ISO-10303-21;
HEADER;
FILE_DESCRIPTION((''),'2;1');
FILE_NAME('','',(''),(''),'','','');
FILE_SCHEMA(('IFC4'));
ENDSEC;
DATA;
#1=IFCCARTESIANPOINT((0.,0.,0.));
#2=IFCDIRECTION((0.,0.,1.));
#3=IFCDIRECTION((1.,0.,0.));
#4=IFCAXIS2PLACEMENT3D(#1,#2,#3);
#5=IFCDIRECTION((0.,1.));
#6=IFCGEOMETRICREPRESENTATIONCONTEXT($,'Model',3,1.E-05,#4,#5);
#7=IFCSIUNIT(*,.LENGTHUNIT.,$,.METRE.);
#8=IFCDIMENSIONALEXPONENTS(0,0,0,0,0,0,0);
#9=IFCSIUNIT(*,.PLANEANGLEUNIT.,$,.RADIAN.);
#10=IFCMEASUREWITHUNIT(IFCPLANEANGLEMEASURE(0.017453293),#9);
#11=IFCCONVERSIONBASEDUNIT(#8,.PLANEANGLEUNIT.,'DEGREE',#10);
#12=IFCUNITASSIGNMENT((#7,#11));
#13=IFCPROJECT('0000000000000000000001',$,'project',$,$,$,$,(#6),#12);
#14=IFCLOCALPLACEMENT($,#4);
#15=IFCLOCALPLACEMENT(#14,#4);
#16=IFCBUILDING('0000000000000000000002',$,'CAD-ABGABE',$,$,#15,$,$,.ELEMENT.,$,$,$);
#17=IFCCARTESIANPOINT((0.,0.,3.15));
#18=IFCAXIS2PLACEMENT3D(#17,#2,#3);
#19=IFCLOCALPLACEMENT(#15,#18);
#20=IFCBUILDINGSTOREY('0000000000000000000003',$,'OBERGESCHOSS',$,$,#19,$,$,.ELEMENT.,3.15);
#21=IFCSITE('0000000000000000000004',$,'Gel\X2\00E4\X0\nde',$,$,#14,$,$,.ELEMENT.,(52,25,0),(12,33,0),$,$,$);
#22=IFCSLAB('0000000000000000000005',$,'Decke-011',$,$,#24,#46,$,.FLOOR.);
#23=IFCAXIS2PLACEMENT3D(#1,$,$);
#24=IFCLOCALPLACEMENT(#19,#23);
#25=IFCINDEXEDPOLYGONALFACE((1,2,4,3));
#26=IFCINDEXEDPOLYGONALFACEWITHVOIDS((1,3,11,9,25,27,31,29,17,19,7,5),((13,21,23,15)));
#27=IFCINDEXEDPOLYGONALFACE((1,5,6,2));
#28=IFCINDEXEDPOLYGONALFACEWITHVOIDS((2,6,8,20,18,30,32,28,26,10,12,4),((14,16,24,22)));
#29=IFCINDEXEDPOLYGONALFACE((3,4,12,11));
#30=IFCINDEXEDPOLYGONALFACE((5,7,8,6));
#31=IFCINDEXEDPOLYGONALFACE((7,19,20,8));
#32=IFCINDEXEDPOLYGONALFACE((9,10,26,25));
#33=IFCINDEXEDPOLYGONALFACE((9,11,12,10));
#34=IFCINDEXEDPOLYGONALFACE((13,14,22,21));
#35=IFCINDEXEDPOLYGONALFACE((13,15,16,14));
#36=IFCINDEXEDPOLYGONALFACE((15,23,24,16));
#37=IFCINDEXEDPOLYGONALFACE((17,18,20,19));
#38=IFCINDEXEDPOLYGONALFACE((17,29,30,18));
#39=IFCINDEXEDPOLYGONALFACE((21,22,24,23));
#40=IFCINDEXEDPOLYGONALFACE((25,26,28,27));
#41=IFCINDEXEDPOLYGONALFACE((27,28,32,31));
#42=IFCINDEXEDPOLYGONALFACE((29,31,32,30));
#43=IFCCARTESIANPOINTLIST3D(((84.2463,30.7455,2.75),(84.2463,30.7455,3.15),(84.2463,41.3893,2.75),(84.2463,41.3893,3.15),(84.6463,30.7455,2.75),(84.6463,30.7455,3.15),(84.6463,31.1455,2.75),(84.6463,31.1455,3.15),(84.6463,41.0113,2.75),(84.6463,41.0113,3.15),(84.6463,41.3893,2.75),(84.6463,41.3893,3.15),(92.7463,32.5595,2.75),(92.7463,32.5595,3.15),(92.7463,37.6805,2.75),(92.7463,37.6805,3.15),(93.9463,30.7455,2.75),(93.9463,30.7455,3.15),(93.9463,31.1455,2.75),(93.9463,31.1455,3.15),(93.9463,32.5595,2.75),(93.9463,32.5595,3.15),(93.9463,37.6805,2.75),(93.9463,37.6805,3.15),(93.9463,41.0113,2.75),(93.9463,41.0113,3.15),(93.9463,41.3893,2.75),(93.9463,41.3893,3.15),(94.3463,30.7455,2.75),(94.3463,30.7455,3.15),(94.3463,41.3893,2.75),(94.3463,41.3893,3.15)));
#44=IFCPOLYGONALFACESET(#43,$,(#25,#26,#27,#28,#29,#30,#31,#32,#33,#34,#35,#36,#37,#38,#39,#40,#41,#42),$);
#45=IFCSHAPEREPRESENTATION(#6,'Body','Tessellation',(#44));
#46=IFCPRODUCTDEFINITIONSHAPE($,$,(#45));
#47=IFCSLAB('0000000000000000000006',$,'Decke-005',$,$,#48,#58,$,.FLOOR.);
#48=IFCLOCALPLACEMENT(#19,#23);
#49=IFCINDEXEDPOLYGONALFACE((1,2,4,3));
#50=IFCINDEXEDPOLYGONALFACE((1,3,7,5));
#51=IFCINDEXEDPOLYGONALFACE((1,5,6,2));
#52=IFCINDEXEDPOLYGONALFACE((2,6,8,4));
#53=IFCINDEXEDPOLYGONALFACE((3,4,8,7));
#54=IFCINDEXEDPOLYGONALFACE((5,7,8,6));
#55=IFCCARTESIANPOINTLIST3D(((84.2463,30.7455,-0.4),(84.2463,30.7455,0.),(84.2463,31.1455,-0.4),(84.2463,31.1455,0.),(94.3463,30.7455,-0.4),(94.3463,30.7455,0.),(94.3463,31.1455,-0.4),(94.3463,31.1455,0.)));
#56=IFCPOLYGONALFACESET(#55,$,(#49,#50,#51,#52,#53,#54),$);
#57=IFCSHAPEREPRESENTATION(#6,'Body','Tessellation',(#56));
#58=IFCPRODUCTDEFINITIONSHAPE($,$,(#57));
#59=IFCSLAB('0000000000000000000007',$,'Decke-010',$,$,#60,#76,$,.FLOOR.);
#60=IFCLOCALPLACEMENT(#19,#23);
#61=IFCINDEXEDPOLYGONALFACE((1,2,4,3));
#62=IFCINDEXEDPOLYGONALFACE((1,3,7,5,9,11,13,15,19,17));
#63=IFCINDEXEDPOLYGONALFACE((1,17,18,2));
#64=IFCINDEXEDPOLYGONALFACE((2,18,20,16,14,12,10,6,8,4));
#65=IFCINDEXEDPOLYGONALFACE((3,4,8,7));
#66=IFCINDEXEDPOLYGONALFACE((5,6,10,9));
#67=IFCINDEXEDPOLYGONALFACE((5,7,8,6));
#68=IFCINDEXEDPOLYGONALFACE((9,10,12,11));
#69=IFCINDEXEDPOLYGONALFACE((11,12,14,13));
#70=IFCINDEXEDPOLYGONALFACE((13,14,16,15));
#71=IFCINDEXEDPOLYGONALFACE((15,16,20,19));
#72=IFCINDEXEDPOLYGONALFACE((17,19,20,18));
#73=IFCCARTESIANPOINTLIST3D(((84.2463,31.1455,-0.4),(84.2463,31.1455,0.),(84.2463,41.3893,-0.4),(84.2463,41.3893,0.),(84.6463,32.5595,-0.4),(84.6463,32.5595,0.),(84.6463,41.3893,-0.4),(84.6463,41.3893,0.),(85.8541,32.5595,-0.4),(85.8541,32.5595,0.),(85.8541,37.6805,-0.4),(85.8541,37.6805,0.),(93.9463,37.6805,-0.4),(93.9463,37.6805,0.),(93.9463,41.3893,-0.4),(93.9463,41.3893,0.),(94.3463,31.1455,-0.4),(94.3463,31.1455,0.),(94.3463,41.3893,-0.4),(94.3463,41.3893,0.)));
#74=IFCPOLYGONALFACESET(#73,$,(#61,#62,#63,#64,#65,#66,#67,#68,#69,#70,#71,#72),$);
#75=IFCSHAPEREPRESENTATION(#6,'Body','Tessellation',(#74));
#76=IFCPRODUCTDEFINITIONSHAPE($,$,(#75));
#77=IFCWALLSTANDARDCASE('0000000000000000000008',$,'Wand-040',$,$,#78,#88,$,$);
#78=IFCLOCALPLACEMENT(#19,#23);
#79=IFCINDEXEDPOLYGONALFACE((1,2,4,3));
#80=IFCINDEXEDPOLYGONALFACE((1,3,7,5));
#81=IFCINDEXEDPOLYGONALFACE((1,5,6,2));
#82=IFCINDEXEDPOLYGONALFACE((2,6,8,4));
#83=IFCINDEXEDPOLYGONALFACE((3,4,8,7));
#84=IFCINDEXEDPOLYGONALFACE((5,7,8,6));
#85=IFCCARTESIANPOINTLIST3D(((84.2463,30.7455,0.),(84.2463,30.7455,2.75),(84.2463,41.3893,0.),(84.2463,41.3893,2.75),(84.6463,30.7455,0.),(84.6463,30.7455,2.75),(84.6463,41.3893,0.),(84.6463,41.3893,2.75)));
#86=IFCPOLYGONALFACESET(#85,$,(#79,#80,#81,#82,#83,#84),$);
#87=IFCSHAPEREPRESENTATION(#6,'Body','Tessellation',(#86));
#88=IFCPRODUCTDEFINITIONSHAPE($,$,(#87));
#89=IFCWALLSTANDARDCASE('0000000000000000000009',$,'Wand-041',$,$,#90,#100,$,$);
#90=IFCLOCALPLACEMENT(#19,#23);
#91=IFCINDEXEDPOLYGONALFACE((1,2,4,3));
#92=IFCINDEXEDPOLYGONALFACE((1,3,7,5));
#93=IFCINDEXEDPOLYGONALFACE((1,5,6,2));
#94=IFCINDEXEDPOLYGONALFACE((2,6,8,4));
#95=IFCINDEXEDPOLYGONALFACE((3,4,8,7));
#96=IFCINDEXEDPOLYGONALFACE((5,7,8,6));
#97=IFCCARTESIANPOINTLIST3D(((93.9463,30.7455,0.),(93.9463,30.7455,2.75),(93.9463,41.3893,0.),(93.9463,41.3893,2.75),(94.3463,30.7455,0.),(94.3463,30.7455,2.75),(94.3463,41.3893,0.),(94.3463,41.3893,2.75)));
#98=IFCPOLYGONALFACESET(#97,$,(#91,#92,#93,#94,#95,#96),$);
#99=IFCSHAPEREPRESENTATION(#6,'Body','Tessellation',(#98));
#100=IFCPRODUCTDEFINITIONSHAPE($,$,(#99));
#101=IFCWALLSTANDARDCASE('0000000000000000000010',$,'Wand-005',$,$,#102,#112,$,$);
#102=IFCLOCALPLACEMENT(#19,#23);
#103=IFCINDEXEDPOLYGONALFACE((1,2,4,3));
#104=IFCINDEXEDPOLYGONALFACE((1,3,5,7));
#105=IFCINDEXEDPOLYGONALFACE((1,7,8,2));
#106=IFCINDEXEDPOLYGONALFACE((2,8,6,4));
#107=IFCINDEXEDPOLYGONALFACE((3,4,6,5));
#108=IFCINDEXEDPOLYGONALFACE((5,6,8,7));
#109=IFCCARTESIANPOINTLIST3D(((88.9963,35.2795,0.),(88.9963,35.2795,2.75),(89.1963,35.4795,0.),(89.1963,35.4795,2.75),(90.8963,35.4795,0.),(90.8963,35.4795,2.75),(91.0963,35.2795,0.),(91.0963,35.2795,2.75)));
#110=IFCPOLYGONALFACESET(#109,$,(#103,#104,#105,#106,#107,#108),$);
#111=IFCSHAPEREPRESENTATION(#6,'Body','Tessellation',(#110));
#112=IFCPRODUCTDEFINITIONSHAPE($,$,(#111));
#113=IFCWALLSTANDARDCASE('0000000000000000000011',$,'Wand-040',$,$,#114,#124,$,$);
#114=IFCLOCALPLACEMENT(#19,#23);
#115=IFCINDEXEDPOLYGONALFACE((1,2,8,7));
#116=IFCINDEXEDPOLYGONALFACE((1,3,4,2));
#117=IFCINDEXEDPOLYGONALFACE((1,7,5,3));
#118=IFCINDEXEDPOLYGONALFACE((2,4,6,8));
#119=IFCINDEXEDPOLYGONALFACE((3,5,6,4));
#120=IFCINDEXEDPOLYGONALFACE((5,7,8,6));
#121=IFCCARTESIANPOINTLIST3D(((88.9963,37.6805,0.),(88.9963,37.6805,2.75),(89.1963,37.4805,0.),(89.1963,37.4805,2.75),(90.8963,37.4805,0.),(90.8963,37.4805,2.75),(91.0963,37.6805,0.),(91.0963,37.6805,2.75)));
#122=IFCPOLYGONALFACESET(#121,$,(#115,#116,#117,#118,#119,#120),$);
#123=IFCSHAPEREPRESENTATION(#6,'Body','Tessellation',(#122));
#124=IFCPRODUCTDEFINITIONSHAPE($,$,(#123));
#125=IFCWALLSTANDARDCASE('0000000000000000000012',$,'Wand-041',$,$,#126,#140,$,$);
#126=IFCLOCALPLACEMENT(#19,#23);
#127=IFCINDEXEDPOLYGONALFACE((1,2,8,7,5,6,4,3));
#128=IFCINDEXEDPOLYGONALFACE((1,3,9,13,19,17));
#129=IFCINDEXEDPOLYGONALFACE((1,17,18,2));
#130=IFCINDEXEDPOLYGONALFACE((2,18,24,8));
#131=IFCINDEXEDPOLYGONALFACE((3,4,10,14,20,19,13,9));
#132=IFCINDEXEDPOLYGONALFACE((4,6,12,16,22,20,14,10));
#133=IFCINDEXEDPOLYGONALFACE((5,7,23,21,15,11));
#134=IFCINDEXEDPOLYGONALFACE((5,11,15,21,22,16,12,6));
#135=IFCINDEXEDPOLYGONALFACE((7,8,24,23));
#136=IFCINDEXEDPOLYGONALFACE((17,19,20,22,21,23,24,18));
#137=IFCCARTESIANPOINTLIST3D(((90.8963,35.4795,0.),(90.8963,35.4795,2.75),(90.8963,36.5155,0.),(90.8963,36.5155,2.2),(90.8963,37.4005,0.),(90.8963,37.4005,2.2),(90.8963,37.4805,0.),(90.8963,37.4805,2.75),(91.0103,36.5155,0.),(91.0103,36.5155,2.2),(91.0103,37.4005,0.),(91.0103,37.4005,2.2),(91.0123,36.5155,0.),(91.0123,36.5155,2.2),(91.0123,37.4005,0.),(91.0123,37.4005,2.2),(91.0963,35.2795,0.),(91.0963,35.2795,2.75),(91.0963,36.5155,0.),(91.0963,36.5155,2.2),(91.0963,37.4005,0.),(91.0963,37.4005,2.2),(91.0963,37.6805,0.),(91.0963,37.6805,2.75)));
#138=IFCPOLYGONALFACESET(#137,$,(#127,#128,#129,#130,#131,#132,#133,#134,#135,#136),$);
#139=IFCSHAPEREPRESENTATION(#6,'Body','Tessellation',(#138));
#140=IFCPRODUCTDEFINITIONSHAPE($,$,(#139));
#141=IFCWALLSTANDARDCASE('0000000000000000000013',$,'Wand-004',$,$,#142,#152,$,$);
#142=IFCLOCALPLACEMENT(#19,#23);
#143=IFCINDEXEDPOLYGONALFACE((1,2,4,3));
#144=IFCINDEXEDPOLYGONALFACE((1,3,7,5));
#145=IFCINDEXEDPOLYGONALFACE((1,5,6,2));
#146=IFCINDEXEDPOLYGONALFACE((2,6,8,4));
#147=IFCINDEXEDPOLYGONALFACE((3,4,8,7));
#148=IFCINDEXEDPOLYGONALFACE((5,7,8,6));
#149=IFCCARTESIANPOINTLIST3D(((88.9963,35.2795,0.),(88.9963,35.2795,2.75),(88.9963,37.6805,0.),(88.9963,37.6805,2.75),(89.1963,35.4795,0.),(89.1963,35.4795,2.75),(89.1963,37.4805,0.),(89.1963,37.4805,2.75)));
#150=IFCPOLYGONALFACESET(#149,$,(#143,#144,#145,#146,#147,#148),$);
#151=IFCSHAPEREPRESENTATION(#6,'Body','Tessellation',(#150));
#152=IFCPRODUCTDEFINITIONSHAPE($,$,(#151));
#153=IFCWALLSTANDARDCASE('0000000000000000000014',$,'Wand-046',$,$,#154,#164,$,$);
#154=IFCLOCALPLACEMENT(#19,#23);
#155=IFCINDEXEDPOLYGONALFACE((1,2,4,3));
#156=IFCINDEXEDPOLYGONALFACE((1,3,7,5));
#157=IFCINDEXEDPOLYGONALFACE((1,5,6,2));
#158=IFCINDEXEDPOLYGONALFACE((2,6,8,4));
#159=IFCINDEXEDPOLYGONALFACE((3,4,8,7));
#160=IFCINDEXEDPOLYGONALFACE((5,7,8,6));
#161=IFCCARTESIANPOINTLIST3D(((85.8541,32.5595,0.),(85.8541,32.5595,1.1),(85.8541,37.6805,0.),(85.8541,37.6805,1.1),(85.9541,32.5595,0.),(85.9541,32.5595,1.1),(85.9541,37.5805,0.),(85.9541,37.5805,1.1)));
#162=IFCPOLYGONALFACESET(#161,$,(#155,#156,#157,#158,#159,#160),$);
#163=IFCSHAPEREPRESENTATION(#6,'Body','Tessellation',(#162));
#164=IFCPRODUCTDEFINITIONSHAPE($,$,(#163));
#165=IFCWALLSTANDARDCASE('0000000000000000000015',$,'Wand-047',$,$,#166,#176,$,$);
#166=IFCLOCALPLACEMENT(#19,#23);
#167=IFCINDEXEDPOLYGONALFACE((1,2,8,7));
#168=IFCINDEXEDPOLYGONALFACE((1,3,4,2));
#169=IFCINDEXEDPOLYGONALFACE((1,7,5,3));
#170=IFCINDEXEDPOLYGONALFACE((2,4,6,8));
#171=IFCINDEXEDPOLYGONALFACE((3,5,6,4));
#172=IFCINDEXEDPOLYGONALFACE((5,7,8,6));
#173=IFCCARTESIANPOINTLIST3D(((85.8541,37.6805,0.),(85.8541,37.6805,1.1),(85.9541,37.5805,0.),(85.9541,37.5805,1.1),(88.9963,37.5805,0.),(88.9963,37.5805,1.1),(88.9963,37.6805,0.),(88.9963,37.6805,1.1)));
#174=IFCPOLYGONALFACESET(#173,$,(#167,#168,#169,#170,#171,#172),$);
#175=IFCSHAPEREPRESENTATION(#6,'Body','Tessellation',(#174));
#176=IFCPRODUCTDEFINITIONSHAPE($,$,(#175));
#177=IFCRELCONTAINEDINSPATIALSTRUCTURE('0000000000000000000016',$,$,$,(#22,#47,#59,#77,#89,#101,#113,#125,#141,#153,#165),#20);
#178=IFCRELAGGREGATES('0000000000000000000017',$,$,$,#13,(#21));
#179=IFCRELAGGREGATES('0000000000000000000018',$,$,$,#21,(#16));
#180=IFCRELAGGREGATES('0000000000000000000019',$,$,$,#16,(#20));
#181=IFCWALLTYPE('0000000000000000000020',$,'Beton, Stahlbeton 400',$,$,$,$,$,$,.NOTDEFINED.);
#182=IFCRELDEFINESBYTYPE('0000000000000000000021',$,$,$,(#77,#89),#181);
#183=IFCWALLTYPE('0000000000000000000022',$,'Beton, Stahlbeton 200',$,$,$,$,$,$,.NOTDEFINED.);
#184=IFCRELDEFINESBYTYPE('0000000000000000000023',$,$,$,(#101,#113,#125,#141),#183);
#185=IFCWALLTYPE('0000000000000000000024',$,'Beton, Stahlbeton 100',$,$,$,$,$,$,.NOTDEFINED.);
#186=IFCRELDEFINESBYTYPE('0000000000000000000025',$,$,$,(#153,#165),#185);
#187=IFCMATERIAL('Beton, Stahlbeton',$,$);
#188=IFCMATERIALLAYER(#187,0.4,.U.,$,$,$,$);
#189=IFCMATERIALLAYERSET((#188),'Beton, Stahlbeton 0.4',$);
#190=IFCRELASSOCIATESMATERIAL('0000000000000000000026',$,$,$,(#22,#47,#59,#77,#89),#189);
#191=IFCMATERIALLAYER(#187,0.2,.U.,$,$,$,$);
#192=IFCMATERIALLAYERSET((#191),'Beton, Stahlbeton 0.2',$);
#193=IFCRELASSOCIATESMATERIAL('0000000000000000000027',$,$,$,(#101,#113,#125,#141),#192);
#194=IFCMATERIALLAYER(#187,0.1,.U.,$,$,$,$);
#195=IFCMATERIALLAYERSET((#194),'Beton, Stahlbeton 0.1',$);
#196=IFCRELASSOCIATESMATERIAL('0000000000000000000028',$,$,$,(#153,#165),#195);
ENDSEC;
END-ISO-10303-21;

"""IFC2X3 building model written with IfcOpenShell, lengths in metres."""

from ifc_helpers import new_model, entity, si_unit, converted_unit, direction, frame, origin_with_axes, origin_2d_with_axis, place, context, project, spatial, polyline, rectangle, outline, extrude, material, layer, layer_set, layer_usage, type_object, element, save


model = new_model("IFC2X3")

# Units and contexts
model_context = context("Model", 3, precision=1e-05, world=origin_with_axes(), true_north=direction((0.0, 1.0)))
ifc_project = project(units=[si_unit("LENGTHUNIT", "METRE"), converted_unit("PLANEANGLEUNIT", "DEGREE", entity("IfcPlaneAngleMeasure", 0.017453293), si_unit("PLANEANGLEUNIT", "RADIAN"), dimensions=[0, 0, 0, 0, 0, 0, 0])], contexts=[model_context])

# Site, building, storey
site_placement = place(None, origin_with_axes())
site = spatial("IfcSite", under=ifc_project, at=site_placement, Name="Gelände", CompositionType="ELEMENT", RefLatitude=(52, 25, 0), RefLongitude=(12, 33, 0))
building_placement = place(site_placement, origin_with_axes())
building = spatial("IfcBuilding", under=site, at=building_placement, Name="CAD-ABGABE", CompositionType="ELEMENT")
storey_placement = place(building_placement, frame((0.0, 0.0, 3.15), z_axis=(0.0, 0.0, 1.0), x_axis=(1.0, 0.0, 0.0)))
storey = spatial("IfcBuildingStorey", under=building, at=storey_placement, Name="OBERGESCHOSS", CompositionType="ELEMENT", Elevation=3.15)

# Slabs
ifc_material = material(Name="Beton, Stahlbeton")
ifc_layer_1 = layer(ifc_material, 0.4, ventilated="UNKNOWN")
ifc_layer_set_1 = layer_set([ifc_layer_1], Name="Beton, Stahlbeton 0.4")
ifc_layer_usage_1 = layer_usage(ifc_layer_set_1, "AXIS3", "NEGATIVE", 0.4)
slab_1_placement = place(storey_placement, frame((84.2463, 41.3893, 2.75), z_axis=(0.0, 0.0, 1.0), x_axis=(1.0, 0.0, 0.0)))
element("IfcSlab", 1, at=slab_1_placement, inside=storey, material=ifc_layer_usage_1, Name="Decke-011", PredefinedType="FLOOR", context=model_context, shape_type="SweptSolid", body=[
    extrude(outline(polyline([(0.0, 0.0), (0.0, -10.6437), (0.4, -10.6437), (0.4, -10.2437), (9.7, -10.2437), (9.7, -10.6437), (10.1, -10.6437), (10.1, 0.0), (9.7, 0.0), (9.7, -0.378), (0.4, -0.378), (0.4, 0.0), (0.0, 0.0)]), holes=[polyline([(8.5, -3.7087), (9.7, -3.7087), (9.7, -8.8298), (8.5, -8.8298), (8.5, -3.7087)])]), origin_with_axes(), (0.0, 0.0, 1.0), 0.4),
])
ifc_layer_usage_2 = layer_usage(ifc_layer_set_1, "AXIS3", "NEGATIVE", 0.4)
slab_2_placement = place(storey_placement, frame((84.2463, 31.1455, -0.4), z_axis=(0.0, 0.0, 1.0), x_axis=(1.0, 0.0, 0.0)))
element("IfcSlab", 2, at=slab_2_placement, inside=storey, material=ifc_layer_usage_2, Name="Decke-005", PredefinedType="FLOOR", context=model_context, shape_type="SweptSolid", body=[
    extrude(outline(polyline([(0.0, 0.0), (0.0, -0.4), (10.1, -0.4), (10.1, 0.0), (0.0, 0.0)])), origin_with_axes(), (0.0, 0.0, 1.0), 0.4),
])
ifc_layer_usage_3 = layer_usage(ifc_layer_set_1, "AXIS3", "NEGATIVE", 0.4)
slab_3_placement = place(storey_placement, frame((84.6463, 41.3893, -0.4), z_axis=(0.0, 0.0, 1.0), x_axis=(1.0, 0.0, 0.0)))
element("IfcSlab", 3, at=slab_3_placement, inside=storey, material=ifc_layer_usage_3, Name="Decke-010", PredefinedType="FLOOR", context=model_context, shape_type="SweptSolid", body=[
    extrude(outline(polyline([(0.0, 0.0), (-0.4, 0.0), (-0.4, -10.2437), (9.7, -10.2437), (9.7, 0.0), (9.3, 0.0), (9.3, -3.7087), (1.2077, -3.7087), (1.2077, -8.8298), (0.0, -8.8298), (0.0, 0.0)])), origin_with_axes(), (0.0, 0.0, 1.0), 0.4),
])

# Shared definitions
wall_type_1 = type_object("IfcWallType", Name="Beton, Stahlbeton 400", PredefinedType="NOTDEFINED")

# Walls
ifc_layer_usage_4 = layer_usage(ifc_layer_set_1, "AXIS2", "POSITIVE", 0.0)
wall_1_placement = place(storey_placement, frame((84.2463, 41.3893, 0.0), z_axis=(0.0, 0.0, 1.0), x_axis=(0.0, -1.0, 0.0)))
element("IfcWallStandardCase", 4, at=wall_1_placement, inside=storey, type_object=wall_type_1, material=ifc_layer_usage_4, Name="Wand-040", context=model_context, shape_type="SweptSolid", body=[
    extrude(outline(polyline([(0.0, 0.0), (10.6437, 0.0), (10.6437, 0.4), (0.0, 0.4), (0.0, 0.0)])), origin_with_axes(), (0.0, 0.0, 1.0), 2.75),
])
ifc_layer_usage_5 = layer_usage(ifc_layer_set_1, "AXIS2", "POSITIVE", 0.0)
wall_2_placement = place(storey_placement, frame((94.3463, 30.7455, 0.0), z_axis=(0.0, 0.0, 1.0), x_axis=(0.0, 1.0, 0.0)))
element("IfcWallStandardCase", 5, at=wall_2_placement, inside=storey, type_object=wall_type_1, material=ifc_layer_usage_5, Name="Wand-041", context=model_context, shape_type="SweptSolid", body=[
    extrude(outline(polyline([(0.0, 0.0), (10.6437, 0.0), (10.6437, 0.4), (0.0, 0.4), (0.0, 0.0)])), origin_with_axes(), (0.0, 0.0, 1.0), 2.75),
])
ifc_layer_2 = layer(ifc_material, 0.2, ventilated="UNKNOWN")
ifc_layer_set_2 = layer_set([ifc_layer_2], Name="Beton, Stahlbeton 0.2")
ifc_layer_usage_6 = layer_usage(ifc_layer_set_2, "AXIS2", "NEGATIVE", 0.0)
wall_type_2 = type_object("IfcWallType", Name="Beton, Stahlbeton 200", PredefinedType="NOTDEFINED")
wall_3_placement = place(storey_placement, frame((88.9963, 35.4795, 0.0), z_axis=(0.0, 0.0, 1.0), x_axis=(1.0, 0.0, 0.0)))
element("IfcWallStandardCase", 6, at=wall_3_placement, inside=storey, type_object=wall_type_2, material=ifc_layer_usage_6, Name="Wand-005", context=model_context, shape_type="SweptSolid", body=[
    extrude(outline(polyline([(0.0, -0.2), (2.1, -0.2), (1.9, 0.0), (0.2, 0.0), (0.0, -0.2)])), origin_with_axes(), (0.0, 0.0, 1.0), 2.75),
])
ifc_layer_usage_7 = layer_usage(ifc_layer_set_2, "AXIS2", "POSITIVE", 0.0)
wall_4_placement = place(storey_placement, frame((91.0963, 37.6805, 0.0), z_axis=(0.0, 0.0, 1.0), x_axis=(-1.0, 0.0, 0.0)))
element("IfcWallStandardCase", 7, at=wall_4_placement, inside=storey, type_object=wall_type_2, material=ifc_layer_usage_7, Name="Wand-040", context=model_context, shape_type="SweptSolid", body=[
    extrude(outline(polyline([(0.0, 0.0), (2.1, 0.0), (1.9, 0.2), (0.2, 0.2), (0.0, 0.0)])), origin_with_axes(), (0.0, 0.0, 1.0), 2.75),
])

# Wall, opening
ifc_layer_usage_8 = layer_usage(ifc_layer_set_2, "AXIS2", "NEGATIVE", 0.0)
wall_5_placement = place(storey_placement, frame((91.0963, 37.6805, 0.0), z_axis=(0.0, 0.0, 1.0), x_axis=(0.0, -1.0, 0.0)))
wall_5 = element("IfcWallStandardCase", 8, at=wall_5_placement, inside=storey, type_object=wall_type_2, material=ifc_layer_usage_8, Name="Wand-041", context=model_context, shape_type="SweptSolid", body=[
    extrude(outline(polyline([(0.2, -0.2), (2.201, -0.2), (2.401, 0.0), (0.0, 0.0), (0.2, -0.2)])), origin_with_axes(), (0.0, 0.0, 1.0), 2.75),
])
opening_1_placement = place(wall_5_placement, frame((0.7225, 0.0, 0.0), z_axis=(0.0, 0.0, 1.0), x_axis=(1.0, 0.0, 0.0)))
element("IfcOpeningElement", 9, at=opening_1_placement, cuts=wall_5, context=model_context, shape_type="SweptSolid", body=[
    extrude(rectangle(XDim=0.885, YDim=2.2, at=origin_2d_with_axis()), frame((0.0, -0.601, 1.1), z_axis=(0.0, 1.0, 0.0), x_axis=(1.0, 0.0, 0.0)), (0.0, 0.0, 1.0), 0.517),
    extrude(rectangle(XDim=0.885, YDim=2.2, at=origin_2d_with_axis()), frame((0.0, 0.401, 1.1), z_axis=(0.0, -1.0, 0.0), x_axis=(1.0, 0.0, 0.0)), (0.0, 0.0, 1.0), 0.487),
])

# Wall
ifc_layer_usage_9 = layer_usage(ifc_layer_set_2, "AXIS2", "POSITIVE", 0.0)
wall_6_placement = place(storey_placement, frame((88.9963, 37.6805, 0.0), z_axis=(0.0, 0.0, 1.0), x_axis=(0.0, -1.0, 0.0)))
element("IfcWallStandardCase", 10, at=wall_6_placement, inside=storey, type_object=wall_type_2, material=ifc_layer_usage_9, Name="Wand-004", context=model_context, shape_type="SweptSolid", body=[
    extrude(outline(polyline([(0.0, 0.0), (2.401, 0.0), (2.201, 0.2), (0.2, 0.2), (0.0, 0.0)])), origin_with_axes(), (0.0, 0.0, 1.0), 2.75),
])

# Shared definitions
ifc_layer_3 = layer(ifc_material, 0.1, ventilated="UNKNOWN")
ifc_layer_set_3 = layer_set([ifc_layer_3], Name="Beton, Stahlbeton 0.1")
wall_type_3 = type_object("IfcWallType", Name="Beton, Stahlbeton 100", PredefinedType="NOTDEFINED")

# Walls
ifc_layer_usage_10 = layer_usage(ifc_layer_set_3, "AXIS2", "NEGATIVE", 0.0)
wall_7_placement = place(storey_placement, frame((85.8541, 32.5595, 0.0), z_axis=(0.0, 0.0, 1.0), x_axis=(0.0, 1.0, 0.0)))
element("IfcWallStandardCase", 11, at=wall_7_placement, inside=storey, type_object=wall_type_3, material=ifc_layer_usage_10, Name="Wand-046", context=model_context, shape_type="SweptSolid", body=[
    extrude(outline(polyline([(0.0, -0.1), (5.021, -0.1), (5.121, 0.0), (0.0, 0.0), (0.0, -0.1)])), origin_with_axes(), (0.0, 0.0, 1.0), 1.1),
])
ifc_layer_usage_11 = layer_usage(ifc_layer_set_3, "AXIS2", "POSITIVE", 0.0)
wall_8_placement = place(storey_placement, frame((88.9963, 37.6805, 0.0), z_axis=(0.0, 0.0, 1.0), x_axis=(-1.0, 0.0, 0.0)))
element("IfcWallStandardCase", 12, at=wall_8_placement, inside=storey, type_object=wall_type_3, material=ifc_layer_usage_11, Name="Wand-047", context=model_context, shape_type="SweptSolid", body=[
    extrude(outline(polyline([(0.0, 0.0), (3.1423, 0.0), (3.0423, 0.1), (0.0, 0.1), (0.0, 0.0)])), origin_with_axes(), (0.0, 0.0, 1.0), 1.1),
])

save(model, "model.ifc")
